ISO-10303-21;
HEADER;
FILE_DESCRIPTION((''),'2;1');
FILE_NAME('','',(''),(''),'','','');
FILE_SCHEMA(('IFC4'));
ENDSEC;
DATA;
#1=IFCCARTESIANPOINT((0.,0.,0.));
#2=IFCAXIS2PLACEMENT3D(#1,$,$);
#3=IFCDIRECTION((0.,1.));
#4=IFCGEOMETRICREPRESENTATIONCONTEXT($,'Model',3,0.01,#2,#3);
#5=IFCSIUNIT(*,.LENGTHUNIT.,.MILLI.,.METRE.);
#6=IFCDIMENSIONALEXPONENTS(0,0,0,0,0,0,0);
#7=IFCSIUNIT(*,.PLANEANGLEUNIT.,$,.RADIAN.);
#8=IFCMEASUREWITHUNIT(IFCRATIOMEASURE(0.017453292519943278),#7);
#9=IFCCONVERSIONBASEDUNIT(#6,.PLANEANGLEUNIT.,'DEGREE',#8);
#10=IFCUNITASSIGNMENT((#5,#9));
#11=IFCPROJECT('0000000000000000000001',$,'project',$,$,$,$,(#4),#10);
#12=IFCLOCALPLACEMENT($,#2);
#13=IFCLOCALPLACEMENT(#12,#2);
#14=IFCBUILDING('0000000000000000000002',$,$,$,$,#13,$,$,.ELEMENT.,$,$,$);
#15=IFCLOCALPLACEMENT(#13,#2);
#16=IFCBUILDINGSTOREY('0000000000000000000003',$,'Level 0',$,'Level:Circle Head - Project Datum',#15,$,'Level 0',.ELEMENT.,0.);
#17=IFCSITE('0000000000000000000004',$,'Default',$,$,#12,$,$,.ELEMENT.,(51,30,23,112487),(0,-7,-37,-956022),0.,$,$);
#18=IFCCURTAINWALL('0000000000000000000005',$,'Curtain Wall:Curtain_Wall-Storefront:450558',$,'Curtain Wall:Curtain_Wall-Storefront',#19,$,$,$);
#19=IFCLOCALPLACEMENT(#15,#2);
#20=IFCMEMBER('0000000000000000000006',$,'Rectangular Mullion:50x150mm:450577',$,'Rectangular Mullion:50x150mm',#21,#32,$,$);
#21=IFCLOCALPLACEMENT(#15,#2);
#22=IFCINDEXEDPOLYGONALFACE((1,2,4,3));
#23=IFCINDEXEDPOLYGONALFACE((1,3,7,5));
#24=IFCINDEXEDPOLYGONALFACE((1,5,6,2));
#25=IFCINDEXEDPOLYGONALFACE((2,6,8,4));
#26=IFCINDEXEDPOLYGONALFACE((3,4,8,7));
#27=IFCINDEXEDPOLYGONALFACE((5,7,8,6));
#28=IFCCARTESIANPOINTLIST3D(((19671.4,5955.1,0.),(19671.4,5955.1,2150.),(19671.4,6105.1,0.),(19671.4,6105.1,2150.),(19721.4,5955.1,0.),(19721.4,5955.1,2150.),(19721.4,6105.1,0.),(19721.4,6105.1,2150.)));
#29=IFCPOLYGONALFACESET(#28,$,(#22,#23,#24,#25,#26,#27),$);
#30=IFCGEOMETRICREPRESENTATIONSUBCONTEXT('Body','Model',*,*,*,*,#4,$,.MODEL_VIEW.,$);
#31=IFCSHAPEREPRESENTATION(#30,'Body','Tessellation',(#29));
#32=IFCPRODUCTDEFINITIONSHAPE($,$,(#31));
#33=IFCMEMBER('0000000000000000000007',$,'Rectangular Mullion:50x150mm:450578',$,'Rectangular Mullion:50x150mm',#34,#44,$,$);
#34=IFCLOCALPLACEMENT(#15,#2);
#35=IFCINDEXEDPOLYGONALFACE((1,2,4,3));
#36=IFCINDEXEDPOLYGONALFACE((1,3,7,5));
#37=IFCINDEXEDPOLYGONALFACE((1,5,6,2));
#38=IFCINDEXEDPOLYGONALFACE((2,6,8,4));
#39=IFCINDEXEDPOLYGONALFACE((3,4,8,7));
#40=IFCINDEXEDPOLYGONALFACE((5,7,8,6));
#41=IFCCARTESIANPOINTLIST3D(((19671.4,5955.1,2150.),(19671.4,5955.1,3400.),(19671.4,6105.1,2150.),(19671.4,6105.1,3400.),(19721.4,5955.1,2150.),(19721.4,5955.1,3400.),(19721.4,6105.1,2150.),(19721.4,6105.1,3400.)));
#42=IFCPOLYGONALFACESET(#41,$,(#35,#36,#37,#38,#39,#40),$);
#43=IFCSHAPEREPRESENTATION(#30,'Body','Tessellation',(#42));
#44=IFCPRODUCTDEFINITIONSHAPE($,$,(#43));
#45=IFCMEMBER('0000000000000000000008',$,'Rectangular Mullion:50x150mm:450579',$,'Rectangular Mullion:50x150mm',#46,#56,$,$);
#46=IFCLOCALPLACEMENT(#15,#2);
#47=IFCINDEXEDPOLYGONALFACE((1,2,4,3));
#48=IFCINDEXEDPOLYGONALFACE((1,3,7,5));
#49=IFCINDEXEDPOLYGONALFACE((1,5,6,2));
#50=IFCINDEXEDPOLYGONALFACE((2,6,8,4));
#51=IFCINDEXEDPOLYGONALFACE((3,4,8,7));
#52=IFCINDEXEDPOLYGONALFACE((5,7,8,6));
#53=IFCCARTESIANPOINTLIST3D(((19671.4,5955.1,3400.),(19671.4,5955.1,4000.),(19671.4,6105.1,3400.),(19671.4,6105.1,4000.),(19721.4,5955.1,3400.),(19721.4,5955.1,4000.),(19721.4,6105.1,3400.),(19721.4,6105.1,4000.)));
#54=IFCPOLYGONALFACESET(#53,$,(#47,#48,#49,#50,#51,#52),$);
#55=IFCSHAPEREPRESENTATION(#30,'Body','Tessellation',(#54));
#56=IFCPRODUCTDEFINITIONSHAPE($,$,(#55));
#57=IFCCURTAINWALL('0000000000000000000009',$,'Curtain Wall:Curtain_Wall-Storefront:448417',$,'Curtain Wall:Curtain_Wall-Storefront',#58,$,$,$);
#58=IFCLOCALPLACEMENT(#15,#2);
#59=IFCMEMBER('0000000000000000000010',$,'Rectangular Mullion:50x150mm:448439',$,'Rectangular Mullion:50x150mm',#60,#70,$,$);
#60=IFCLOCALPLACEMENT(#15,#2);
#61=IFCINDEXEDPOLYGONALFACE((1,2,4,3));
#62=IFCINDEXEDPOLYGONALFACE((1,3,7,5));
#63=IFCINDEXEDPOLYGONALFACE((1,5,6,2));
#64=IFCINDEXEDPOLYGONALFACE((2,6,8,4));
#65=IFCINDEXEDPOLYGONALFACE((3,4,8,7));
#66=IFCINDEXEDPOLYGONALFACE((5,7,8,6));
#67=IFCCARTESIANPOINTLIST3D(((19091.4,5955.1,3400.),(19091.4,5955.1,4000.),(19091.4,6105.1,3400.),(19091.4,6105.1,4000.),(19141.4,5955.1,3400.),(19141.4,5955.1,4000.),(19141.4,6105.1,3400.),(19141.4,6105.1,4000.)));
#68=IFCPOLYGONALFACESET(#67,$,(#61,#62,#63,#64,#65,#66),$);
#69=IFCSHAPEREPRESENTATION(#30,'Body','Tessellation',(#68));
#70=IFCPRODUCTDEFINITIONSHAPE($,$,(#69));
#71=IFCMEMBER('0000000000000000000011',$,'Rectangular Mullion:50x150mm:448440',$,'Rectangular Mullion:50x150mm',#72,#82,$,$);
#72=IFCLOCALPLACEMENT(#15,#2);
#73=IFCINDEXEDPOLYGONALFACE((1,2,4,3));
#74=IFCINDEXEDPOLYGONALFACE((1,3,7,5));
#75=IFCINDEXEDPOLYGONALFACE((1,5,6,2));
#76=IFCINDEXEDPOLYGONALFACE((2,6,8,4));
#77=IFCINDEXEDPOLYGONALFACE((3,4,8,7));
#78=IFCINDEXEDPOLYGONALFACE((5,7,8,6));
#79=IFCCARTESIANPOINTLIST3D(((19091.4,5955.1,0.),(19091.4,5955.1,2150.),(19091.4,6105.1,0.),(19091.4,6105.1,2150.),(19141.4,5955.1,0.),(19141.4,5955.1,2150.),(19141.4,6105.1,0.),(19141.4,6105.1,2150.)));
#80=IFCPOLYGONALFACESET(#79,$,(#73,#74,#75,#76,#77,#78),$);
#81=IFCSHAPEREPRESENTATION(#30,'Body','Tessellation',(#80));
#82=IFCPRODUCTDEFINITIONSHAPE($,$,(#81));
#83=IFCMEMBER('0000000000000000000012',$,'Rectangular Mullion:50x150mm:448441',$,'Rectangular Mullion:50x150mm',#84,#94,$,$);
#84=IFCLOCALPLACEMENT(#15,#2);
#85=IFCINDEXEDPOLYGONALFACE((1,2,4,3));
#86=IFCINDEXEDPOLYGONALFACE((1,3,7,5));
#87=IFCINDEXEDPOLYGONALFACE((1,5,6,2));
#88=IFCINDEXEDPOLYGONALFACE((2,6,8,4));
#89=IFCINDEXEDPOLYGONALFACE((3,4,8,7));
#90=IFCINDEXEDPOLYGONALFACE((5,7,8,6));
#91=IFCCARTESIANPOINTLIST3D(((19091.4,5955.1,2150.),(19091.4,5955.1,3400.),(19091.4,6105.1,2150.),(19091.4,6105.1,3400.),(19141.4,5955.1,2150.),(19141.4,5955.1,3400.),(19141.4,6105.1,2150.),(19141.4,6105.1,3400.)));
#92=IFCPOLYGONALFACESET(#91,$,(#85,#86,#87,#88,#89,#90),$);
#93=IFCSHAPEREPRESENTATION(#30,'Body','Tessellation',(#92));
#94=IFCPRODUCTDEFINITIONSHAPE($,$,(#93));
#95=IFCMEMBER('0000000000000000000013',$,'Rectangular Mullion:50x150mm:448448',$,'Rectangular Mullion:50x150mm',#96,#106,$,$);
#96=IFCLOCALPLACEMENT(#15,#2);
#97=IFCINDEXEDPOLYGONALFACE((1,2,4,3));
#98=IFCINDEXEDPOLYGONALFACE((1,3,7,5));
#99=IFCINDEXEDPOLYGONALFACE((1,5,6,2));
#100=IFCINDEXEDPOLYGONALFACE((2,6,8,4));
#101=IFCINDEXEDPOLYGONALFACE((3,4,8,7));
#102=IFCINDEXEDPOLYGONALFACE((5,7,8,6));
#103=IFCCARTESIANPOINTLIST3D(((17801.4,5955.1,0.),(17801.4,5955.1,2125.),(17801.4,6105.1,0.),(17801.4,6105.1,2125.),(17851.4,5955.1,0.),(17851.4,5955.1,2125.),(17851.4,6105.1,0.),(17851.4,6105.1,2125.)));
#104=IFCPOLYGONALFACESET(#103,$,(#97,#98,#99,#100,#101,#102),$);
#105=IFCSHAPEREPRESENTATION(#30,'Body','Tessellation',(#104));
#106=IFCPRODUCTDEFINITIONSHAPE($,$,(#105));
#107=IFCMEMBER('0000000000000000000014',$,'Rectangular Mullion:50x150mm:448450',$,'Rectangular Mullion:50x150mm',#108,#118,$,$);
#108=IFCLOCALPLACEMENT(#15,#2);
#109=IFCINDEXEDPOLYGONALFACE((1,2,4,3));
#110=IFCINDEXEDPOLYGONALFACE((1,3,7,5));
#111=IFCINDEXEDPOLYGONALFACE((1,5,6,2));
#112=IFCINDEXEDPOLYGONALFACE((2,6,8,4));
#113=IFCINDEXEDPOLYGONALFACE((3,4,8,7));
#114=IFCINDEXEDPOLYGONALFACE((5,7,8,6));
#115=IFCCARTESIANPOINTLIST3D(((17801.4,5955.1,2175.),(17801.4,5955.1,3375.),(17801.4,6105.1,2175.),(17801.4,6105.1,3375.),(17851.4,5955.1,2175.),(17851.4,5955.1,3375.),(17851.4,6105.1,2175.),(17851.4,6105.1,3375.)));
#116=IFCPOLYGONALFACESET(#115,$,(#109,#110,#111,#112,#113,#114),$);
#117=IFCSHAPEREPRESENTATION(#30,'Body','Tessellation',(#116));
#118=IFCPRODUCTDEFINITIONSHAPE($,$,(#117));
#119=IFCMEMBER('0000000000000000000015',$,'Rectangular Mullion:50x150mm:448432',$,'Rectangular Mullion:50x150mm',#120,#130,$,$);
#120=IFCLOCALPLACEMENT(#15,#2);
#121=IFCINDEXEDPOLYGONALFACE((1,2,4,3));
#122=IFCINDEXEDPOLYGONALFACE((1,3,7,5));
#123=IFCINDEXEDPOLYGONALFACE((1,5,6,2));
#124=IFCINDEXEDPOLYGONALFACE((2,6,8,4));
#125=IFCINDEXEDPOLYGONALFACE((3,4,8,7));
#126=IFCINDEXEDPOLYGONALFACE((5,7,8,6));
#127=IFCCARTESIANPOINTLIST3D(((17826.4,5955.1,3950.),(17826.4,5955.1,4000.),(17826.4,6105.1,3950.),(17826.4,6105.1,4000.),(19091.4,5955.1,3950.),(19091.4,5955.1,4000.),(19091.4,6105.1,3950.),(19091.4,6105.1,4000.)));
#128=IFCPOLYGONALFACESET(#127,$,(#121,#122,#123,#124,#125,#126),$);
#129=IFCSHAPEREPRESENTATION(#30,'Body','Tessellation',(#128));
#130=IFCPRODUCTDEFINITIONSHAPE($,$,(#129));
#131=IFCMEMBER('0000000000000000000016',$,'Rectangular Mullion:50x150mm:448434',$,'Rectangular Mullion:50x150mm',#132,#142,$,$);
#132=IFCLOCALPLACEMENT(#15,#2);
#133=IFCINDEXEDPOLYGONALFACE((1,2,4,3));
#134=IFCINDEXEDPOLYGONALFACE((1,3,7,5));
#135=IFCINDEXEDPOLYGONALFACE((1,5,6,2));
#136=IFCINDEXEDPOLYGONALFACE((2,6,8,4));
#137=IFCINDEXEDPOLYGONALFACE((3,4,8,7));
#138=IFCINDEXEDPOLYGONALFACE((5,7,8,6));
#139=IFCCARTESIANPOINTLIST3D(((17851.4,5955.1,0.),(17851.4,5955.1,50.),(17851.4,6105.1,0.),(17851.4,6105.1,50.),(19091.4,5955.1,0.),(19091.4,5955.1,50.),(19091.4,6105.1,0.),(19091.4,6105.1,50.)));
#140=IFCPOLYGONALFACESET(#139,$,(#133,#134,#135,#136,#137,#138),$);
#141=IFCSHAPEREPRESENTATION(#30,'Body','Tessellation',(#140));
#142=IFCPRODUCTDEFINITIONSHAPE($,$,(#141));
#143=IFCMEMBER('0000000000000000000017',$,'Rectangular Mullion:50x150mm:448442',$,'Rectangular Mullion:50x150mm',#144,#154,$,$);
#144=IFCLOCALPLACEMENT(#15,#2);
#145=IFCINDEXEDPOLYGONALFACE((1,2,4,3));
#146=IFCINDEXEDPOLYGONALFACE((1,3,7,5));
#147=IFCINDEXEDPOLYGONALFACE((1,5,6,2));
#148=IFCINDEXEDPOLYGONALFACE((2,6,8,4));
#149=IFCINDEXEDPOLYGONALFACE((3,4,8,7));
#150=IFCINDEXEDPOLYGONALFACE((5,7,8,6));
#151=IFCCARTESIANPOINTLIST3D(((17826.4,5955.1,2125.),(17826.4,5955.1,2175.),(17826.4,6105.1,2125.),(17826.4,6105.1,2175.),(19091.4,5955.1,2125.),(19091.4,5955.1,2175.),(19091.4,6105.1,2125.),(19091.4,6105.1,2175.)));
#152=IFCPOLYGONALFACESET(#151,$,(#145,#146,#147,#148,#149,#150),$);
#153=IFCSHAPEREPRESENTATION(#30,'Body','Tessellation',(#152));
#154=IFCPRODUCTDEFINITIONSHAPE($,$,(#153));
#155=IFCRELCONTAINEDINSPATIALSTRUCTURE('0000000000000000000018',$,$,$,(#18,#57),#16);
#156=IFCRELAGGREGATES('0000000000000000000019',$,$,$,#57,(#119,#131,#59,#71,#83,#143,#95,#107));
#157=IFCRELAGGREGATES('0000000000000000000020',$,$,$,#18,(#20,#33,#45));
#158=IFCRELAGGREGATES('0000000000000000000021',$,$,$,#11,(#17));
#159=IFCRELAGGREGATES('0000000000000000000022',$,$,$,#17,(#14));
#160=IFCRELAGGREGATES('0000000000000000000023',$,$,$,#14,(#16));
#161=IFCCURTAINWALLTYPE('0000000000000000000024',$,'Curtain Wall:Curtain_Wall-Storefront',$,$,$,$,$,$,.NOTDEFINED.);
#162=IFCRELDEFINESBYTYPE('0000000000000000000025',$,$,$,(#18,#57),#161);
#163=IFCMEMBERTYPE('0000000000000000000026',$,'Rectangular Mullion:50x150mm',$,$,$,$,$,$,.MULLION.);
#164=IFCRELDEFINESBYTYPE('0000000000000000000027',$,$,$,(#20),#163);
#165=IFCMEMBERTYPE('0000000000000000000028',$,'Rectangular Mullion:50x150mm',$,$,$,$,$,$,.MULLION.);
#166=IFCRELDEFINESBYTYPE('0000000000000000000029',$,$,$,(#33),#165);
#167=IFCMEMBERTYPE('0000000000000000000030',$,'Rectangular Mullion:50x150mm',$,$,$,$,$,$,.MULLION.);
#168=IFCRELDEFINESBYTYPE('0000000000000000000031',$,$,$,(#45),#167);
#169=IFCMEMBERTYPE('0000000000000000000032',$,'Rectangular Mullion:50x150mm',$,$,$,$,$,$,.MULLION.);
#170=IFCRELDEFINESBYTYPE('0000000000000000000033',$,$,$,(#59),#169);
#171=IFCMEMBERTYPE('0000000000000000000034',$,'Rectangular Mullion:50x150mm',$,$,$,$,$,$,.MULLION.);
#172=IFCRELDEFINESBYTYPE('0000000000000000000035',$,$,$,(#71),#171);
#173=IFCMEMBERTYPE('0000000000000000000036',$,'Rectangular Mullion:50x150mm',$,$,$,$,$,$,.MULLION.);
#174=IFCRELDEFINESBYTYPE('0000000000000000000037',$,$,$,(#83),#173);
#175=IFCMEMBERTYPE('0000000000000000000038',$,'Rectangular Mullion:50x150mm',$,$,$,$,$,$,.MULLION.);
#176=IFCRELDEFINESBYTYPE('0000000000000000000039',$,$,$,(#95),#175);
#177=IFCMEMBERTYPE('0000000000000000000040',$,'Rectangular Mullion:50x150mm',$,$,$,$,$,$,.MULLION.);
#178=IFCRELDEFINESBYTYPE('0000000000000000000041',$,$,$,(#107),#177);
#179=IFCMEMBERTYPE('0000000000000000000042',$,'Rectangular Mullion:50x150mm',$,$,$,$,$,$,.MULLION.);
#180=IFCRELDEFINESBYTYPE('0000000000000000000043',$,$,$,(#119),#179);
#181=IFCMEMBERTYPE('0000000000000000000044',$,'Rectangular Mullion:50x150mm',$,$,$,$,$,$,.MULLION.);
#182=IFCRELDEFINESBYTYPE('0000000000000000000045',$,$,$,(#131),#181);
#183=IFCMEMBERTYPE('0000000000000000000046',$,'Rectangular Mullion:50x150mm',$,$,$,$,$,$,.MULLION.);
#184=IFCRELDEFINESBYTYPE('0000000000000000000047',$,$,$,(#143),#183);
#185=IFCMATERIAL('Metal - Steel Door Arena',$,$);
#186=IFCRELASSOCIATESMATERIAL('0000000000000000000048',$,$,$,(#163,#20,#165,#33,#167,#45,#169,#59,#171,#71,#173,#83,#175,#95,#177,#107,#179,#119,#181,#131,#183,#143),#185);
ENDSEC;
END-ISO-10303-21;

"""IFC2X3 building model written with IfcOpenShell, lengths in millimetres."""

from ifc_helpers import new_model, entity, si_unit, converted_unit, direction, frame, origin, origin_2d_with_axis, place, context, subcontext, project, spatial, rectangle, extrude, source, transform, mapped, material, type_object, type_shapes, element, aggregate, save


model = new_model("IFC2X3")

# Units and contexts
model_context = context("Model", 3, precision=0.01, world=origin(), true_north=direction((0.0, 1.0)))
body_context = subcontext(model_context, "Body", "Model", "MODEL_VIEW")
ifc_project = project(units=[si_unit("LENGTHUNIT", "METRE", prefix="MILLI"), converted_unit("PLANEANGLEUNIT", "DEGREE", entity("IfcRatioMeasure", 0.017453292519943278), si_unit("PLANEANGLEUNIT", "RADIAN"), dimensions=[0, 0, 0, 0, 0, 0, 0])], contexts=[model_context])

# Site, building, storey
site_placement = place(None, origin())
site = spatial("IfcSite", under=ifc_project, at=site_placement, Name="Default", CompositionType="ELEMENT", RefLatitude=(51, 30, 23, 112487), RefLongitude=(0, -7, -37, -956022), RefElevation=0.0)
building_placement = place(site_placement, origin())
building = spatial("IfcBuilding", under=site, at=building_placement, CompositionType="ELEMENT")
storey_placement = place(building_placement, origin())
storey = spatial("IfcBuildingStorey", under=building, at=storey_placement, Name="Level 0", ObjectType="Level:Circle Head - Project Datum", LongName="Level 0", CompositionType="ELEMENT", Elevation=0.0)

# Curtain walls, members
curtain_wall_type = type_object("IfcCurtainWallType", Name="Curtain Wall:Curtain_Wall-Storefront", PredefinedType="NOTDEFINED")
curtain_wall_1_placement = place(storey_placement, origin())
curtain_wall_1 = element("IfcCurtainWall", 1, at=curtain_wall_1_placement, inside=storey, type_object=curtain_wall_type, Name="Curtain Wall:Curtain_Wall-Storefront:450558", ObjectType="Curtain Wall:Curtain_Wall-Storefront")
ifc_material_1 = material(Name="Metal - Steel Door Arena")
member_type_1 = type_object("IfcMemberType", Name="Rectangular Mullion:50x150mm", PredefinedType="MULLION", material=ifc_material_1)
shared_shape_1 = source(origin(), body_context, "Body", "SweptSolid", [
    extrude(rectangle(XDim=150.0, YDim=50.0, at=origin_2d_with_axis()), frame((-25.0, 0.0, -2150.0), z_axis=(0.0, 0.0, 1.0), x_axis=(0.0, -1.0, 0.0)), (0.0, 0.0, 1.0), 2150.0),
])
type_shapes(member_type_1, [shared_shape_1])
member_1_placement = place(curtain_wall_1_placement, frame((19671.4, 6030.1, 0.0), z_axis=(0.0, 0.0, -1.0), x_axis=(-1.0, 0.0, 0.0)))
member_1 = element("IfcMember", 2, at=member_1_placement, type_object=member_type_1, material=ifc_material_1, Name="Rectangular Mullion:50x150mm:450577", ObjectType="Rectangular Mullion:50x150mm", context=body_context, shape_type="MappedRepresentation", body=[
    mapped(shared_shape_1, transform((0.0, 0.0, 0.0), scale=1.0)),
])
member_type_2 = type_object("IfcMemberType", Name="Rectangular Mullion:50x150mm", PredefinedType="MULLION", material=ifc_material_1)
shared_shape_2 = source(origin(), body_context, "Body", "SweptSolid", [
    extrude(rectangle(XDim=150.0, YDim=50.0, at=origin_2d_with_axis()), frame((-25.0, 0.0, -1250.0), z_axis=(0.0, 0.0, 1.0), x_axis=(0.0, -1.0, 0.0)), (0.0, 0.0, 1.0), 1250.0),
])
type_shapes(member_type_2, [shared_shape_2])
member_2_placement = place(curtain_wall_1_placement, frame((19671.4, 6030.1, 2150.0), z_axis=(0.0, 0.0, -1.0), x_axis=(-1.0, 0.0, 0.0)))
member_2 = element("IfcMember", 3, at=member_2_placement, type_object=member_type_2, material=ifc_material_1, Name="Rectangular Mullion:50x150mm:450578", ObjectType="Rectangular Mullion:50x150mm", context=body_context, shape_type="MappedRepresentation", body=[
    mapped(shared_shape_2, transform((0.0, 0.0, 0.0), scale=1.0)),
])
member_type_3 = type_object("IfcMemberType", Name="Rectangular Mullion:50x150mm", PredefinedType="MULLION", material=ifc_material_1)
shared_shape_3 = source(origin(), body_context, "Body", "SweptSolid", [
    extrude(rectangle(XDim=150.0, YDim=50.0, at=origin_2d_with_axis()), frame((-25.0, 0.0, -600.0), z_axis=(0.0, 0.0, 1.0), x_axis=(0.0, -1.0, 0.0)), (0.0, 0.0, 1.0), 600.0),
])
type_shapes(member_type_3, [shared_shape_3])
member_3_placement = place(curtain_wall_1_placement, frame((19671.4, 6030.1, 3400.0), z_axis=(0.0, 0.0, -1.0), x_axis=(-1.0, 0.0, 0.0)))
member_3 = element("IfcMember", 4, at=member_3_placement, type_object=member_type_3, material=ifc_material_1, Name="Rectangular Mullion:50x150mm:450579", ObjectType="Rectangular Mullion:50x150mm", context=body_context, shape_type="MappedRepresentation", body=[
    mapped(shared_shape_3, transform((0.0, 0.0, 0.0), scale=1.0)),
])
curtain_wall_2_placement = place(storey_placement, origin())
curtain_wall_2 = element("IfcCurtainWall", 5, at=curtain_wall_2_placement, inside=storey, type_object=curtain_wall_type, Name="Curtain Wall:Curtain_Wall-Storefront:448417", ObjectType="Curtain Wall:Curtain_Wall-Storefront")
member_type_4 = type_object("IfcMemberType", Name="Rectangular Mullion:50x150mm", PredefinedType="MULLION", material=ifc_material_1)
shared_shape_4 = source(origin(), body_context, "Body", "SweptSolid", [
    extrude(rectangle(XDim=150.0, YDim=50.0, at=origin_2d_with_axis()), frame((-25.0, 0.0, -600.0), z_axis=(0.0, 0.0, 1.0), x_axis=(0.0, -1.0, 0.0)), (0.0, 0.0, 1.0), 600.0),
])
type_shapes(member_type_4, [shared_shape_4])
member_4_placement = place(curtain_wall_2_placement, frame((19141.4, 6030.1, 4000.0)))
member_4 = element("IfcMember", 6, at=member_4_placement, type_object=member_type_4, material=ifc_material_1, Name="Rectangular Mullion:50x150mm:448439", ObjectType="Rectangular Mullion:50x150mm", context=body_context, shape_type="MappedRepresentation", body=[
    mapped(shared_shape_4, transform((0.0, 0.0, 0.0), scale=1.0)),
])
member_type_5 = type_object("IfcMemberType", Name="Rectangular Mullion:50x150mm", PredefinedType="MULLION", material=ifc_material_1)
shared_shape_5 = source(origin(), body_context, "Body", "SweptSolid", [
    extrude(rectangle(XDim=150.0, YDim=50.0, at=origin_2d_with_axis()), frame((-25.0, 0.0, -2150.0), z_axis=(0.0, 0.0, 1.0), x_axis=(0.0, -1.0, 0.0)), (0.0, 0.0, 1.0), 2150.0),
])
type_shapes(member_type_5, [shared_shape_5])
member_5_placement = place(curtain_wall_2_placement, frame((19141.4, 6030.1, 2150.0)))
member_5 = element("IfcMember", 7, at=member_5_placement, type_object=member_type_5, material=ifc_material_1, Name="Rectangular Mullion:50x150mm:448440", ObjectType="Rectangular Mullion:50x150mm", context=body_context, shape_type="MappedRepresentation", body=[
    mapped(shared_shape_5, transform((0.0, 0.0, 0.0), scale=1.0)),
])
member_type_6 = type_object("IfcMemberType", Name="Rectangular Mullion:50x150mm", PredefinedType="MULLION", material=ifc_material_1)
shared_shape_6 = source(origin(), body_context, "Body", "SweptSolid", [
    extrude(rectangle(XDim=150.0, YDim=50.0, at=origin_2d_with_axis()), frame((-25.0, 0.0, -1250.0), z_axis=(0.0, 0.0, 1.0), x_axis=(0.0, -1.0, 0.0)), (0.0, 0.0, 1.0), 1250.0),
])
type_shapes(member_type_6, [shared_shape_6])
member_6_placement = place(curtain_wall_2_placement, frame((19141.4, 6030.1, 3400.0)))
member_6 = element("IfcMember", 8, at=member_6_placement, type_object=member_type_6, material=ifc_material_1, Name="Rectangular Mullion:50x150mm:448441", ObjectType="Rectangular Mullion:50x150mm", context=body_context, shape_type="MappedRepresentation", body=[
    mapped(shared_shape_6, transform((0.0, 0.0, 0.0), scale=1.0)),
])
member_type_7 = type_object("IfcMemberType", Name="Rectangular Mullion:50x150mm", PredefinedType="MULLION", material=ifc_material_1)
shared_shape_7 = source(origin(), body_context, "Body", "SweptSolid", [
    extrude(rectangle(XDim=150.0, YDim=50.0, at=origin_2d_with_axis()), frame((0.0, 0.0, -2125.0), z_axis=(0.0, 0.0, 1.0), x_axis=(0.0, -1.0, 0.0)), (0.0, 0.0, 1.0), 2125.0),
])
type_shapes(member_type_7, [shared_shape_7])
member_7_placement = place(curtain_wall_2_placement, frame((17826.4, 6030.1, 0.0), z_axis=(0.0, 0.0, -1.0), x_axis=(-1.0, 0.0, 0.0)))
member_7 = element("IfcMember", 9, at=member_7_placement, type_object=member_type_7, material=ifc_material_1, Name="Rectangular Mullion:50x150mm:448448", ObjectType="Rectangular Mullion:50x150mm", context=body_context, shape_type="MappedRepresentation", body=[
    mapped(shared_shape_7, transform((0.0, 0.0, 0.0), scale=1.0)),
])
member_type_8 = type_object("IfcMemberType", Name="Rectangular Mullion:50x150mm", PredefinedType="MULLION", material=ifc_material_1)
shared_shape_8 = source(origin(), body_context, "Body", "SweptSolid", [
    extrude(rectangle(XDim=150.0, YDim=50.0, at=origin_2d_with_axis()), frame((0.0, 0.0, -1200.0), z_axis=(0.0, 0.0, 1.0), x_axis=(0.0, -1.0, 0.0)), (0.0, 0.0, 1.0), 1200.0),
])
type_shapes(member_type_8, [shared_shape_8])
member_8_placement = place(curtain_wall_2_placement, frame((17826.4, 6030.1, 2175.0), z_axis=(0.0, 0.0, -1.0), x_axis=(-1.0, 0.0, 0.0)))
member_8 = element("IfcMember", 10, at=member_8_placement, type_object=member_type_8, material=ifc_material_1, Name="Rectangular Mullion:50x150mm:448450", ObjectType="Rectangular Mullion:50x150mm", context=body_context, shape_type="MappedRepresentation", body=[
    mapped(shared_shape_8, transform((0.0, 0.0, 0.0), scale=1.0)),
])
member_type_9 = type_object("IfcMemberType", Name="Rectangular Mullion:50x150mm", PredefinedType="MULLION", material=ifc_material_1)
shared_shape_9 = source(origin(), body_context, "Body", "SweptSolid", [
    extrude(rectangle(XDim=150.0, YDim=50.0, at=origin_2d_with_axis()), frame((-25.0, 0.0, -1265.0), z_axis=(0.0, 0.0, 1.0), x_axis=(0.0, -1.0, 0.0)), (0.0, 0.0, 1.0), 1265.0),
])
type_shapes(member_type_9, [shared_shape_9])
member_9_placement = place(curtain_wall_2_placement, frame((17826.4, 6030.1, 4000.0), z_axis=(-1.0, 0.0, 0.0), x_axis=(0.0, 0.0, 1.0)))
member_9 = element("IfcMember", 11, at=member_9_placement, type_object=member_type_9, material=ifc_material_1, Name="Rectangular Mullion:50x150mm:448432", ObjectType="Rectangular Mullion:50x150mm", context=body_context, shape_type="MappedRepresentation", body=[
    mapped(shared_shape_9, transform((0.0, 0.0, 0.0), scale=1.0)),
])
member_type_10 = type_object("IfcMemberType", Name="Rectangular Mullion:50x150mm", PredefinedType="MULLION", material=ifc_material_1)
shared_shape_10 = source(origin(), body_context, "Body", "SweptSolid", [
    extrude(rectangle(XDim=150.0, YDim=50.0, at=origin_2d_with_axis()), frame((-25.0, 0.0, -1240.0), z_axis=(0.0, 0.0, 1.0), x_axis=(0.0, -1.0, 0.0)), (0.0, 0.0, 1.0), 1240.0),
])
type_shapes(member_type_10, [shared_shape_10])
member_10_placement = place(curtain_wall_2_placement, frame((19091.4, 6030.1, 0.0), z_axis=(1.0, 0.0, 0.0), x_axis=(0.0, 0.0, -1.0)))
member_10 = element("IfcMember", 12, at=member_10_placement, type_object=member_type_10, material=ifc_material_1, Name="Rectangular Mullion:50x150mm:448434", ObjectType="Rectangular Mullion:50x150mm", context=body_context, shape_type="MappedRepresentation", body=[
    mapped(shared_shape_10, transform((0.0, 0.0, 0.0), scale=1.0)),
])
member_type_11 = type_object("IfcMemberType", Name="Rectangular Mullion:50x150mm", PredefinedType="MULLION", material=ifc_material_1)
shared_shape_11 = source(origin(), body_context, "Body", "SweptSolid", [
    extrude(rectangle(XDim=150.0, YDim=50.0, at=origin_2d_with_axis()), frame((0.0, 0.0, -1265.0), z_axis=(0.0, 0.0, 1.0), x_axis=(0.0, -1.0, 0.0)), (0.0, 0.0, 1.0), 1265.0),
])
type_shapes(member_type_11, [shared_shape_11])
member_11_placement = place(curtain_wall_2_placement, frame((17826.4, 6030.1, 2150.0), z_axis=(-1.0, 0.0, 0.0), x_axis=(0.0, 0.0, 1.0)))
member_11 = element("IfcMember", 13, at=member_11_placement, type_object=member_type_11, material=ifc_material_1, Name="Rectangular Mullion:50x150mm:448442", ObjectType="Rectangular Mullion:50x150mm", context=body_context, shape_type="MappedRepresentation", body=[
    mapped(shared_shape_11, transform((0.0, 0.0, 0.0), scale=1.0)),
])

aggregate(curtain_wall_2, [member_9, member_10, member_4, member_5, member_6, member_11, member_7, member_8])
aggregate(curtain_wall_1, [member_1, member_2, member_3])

save(model, "model.ifc")
